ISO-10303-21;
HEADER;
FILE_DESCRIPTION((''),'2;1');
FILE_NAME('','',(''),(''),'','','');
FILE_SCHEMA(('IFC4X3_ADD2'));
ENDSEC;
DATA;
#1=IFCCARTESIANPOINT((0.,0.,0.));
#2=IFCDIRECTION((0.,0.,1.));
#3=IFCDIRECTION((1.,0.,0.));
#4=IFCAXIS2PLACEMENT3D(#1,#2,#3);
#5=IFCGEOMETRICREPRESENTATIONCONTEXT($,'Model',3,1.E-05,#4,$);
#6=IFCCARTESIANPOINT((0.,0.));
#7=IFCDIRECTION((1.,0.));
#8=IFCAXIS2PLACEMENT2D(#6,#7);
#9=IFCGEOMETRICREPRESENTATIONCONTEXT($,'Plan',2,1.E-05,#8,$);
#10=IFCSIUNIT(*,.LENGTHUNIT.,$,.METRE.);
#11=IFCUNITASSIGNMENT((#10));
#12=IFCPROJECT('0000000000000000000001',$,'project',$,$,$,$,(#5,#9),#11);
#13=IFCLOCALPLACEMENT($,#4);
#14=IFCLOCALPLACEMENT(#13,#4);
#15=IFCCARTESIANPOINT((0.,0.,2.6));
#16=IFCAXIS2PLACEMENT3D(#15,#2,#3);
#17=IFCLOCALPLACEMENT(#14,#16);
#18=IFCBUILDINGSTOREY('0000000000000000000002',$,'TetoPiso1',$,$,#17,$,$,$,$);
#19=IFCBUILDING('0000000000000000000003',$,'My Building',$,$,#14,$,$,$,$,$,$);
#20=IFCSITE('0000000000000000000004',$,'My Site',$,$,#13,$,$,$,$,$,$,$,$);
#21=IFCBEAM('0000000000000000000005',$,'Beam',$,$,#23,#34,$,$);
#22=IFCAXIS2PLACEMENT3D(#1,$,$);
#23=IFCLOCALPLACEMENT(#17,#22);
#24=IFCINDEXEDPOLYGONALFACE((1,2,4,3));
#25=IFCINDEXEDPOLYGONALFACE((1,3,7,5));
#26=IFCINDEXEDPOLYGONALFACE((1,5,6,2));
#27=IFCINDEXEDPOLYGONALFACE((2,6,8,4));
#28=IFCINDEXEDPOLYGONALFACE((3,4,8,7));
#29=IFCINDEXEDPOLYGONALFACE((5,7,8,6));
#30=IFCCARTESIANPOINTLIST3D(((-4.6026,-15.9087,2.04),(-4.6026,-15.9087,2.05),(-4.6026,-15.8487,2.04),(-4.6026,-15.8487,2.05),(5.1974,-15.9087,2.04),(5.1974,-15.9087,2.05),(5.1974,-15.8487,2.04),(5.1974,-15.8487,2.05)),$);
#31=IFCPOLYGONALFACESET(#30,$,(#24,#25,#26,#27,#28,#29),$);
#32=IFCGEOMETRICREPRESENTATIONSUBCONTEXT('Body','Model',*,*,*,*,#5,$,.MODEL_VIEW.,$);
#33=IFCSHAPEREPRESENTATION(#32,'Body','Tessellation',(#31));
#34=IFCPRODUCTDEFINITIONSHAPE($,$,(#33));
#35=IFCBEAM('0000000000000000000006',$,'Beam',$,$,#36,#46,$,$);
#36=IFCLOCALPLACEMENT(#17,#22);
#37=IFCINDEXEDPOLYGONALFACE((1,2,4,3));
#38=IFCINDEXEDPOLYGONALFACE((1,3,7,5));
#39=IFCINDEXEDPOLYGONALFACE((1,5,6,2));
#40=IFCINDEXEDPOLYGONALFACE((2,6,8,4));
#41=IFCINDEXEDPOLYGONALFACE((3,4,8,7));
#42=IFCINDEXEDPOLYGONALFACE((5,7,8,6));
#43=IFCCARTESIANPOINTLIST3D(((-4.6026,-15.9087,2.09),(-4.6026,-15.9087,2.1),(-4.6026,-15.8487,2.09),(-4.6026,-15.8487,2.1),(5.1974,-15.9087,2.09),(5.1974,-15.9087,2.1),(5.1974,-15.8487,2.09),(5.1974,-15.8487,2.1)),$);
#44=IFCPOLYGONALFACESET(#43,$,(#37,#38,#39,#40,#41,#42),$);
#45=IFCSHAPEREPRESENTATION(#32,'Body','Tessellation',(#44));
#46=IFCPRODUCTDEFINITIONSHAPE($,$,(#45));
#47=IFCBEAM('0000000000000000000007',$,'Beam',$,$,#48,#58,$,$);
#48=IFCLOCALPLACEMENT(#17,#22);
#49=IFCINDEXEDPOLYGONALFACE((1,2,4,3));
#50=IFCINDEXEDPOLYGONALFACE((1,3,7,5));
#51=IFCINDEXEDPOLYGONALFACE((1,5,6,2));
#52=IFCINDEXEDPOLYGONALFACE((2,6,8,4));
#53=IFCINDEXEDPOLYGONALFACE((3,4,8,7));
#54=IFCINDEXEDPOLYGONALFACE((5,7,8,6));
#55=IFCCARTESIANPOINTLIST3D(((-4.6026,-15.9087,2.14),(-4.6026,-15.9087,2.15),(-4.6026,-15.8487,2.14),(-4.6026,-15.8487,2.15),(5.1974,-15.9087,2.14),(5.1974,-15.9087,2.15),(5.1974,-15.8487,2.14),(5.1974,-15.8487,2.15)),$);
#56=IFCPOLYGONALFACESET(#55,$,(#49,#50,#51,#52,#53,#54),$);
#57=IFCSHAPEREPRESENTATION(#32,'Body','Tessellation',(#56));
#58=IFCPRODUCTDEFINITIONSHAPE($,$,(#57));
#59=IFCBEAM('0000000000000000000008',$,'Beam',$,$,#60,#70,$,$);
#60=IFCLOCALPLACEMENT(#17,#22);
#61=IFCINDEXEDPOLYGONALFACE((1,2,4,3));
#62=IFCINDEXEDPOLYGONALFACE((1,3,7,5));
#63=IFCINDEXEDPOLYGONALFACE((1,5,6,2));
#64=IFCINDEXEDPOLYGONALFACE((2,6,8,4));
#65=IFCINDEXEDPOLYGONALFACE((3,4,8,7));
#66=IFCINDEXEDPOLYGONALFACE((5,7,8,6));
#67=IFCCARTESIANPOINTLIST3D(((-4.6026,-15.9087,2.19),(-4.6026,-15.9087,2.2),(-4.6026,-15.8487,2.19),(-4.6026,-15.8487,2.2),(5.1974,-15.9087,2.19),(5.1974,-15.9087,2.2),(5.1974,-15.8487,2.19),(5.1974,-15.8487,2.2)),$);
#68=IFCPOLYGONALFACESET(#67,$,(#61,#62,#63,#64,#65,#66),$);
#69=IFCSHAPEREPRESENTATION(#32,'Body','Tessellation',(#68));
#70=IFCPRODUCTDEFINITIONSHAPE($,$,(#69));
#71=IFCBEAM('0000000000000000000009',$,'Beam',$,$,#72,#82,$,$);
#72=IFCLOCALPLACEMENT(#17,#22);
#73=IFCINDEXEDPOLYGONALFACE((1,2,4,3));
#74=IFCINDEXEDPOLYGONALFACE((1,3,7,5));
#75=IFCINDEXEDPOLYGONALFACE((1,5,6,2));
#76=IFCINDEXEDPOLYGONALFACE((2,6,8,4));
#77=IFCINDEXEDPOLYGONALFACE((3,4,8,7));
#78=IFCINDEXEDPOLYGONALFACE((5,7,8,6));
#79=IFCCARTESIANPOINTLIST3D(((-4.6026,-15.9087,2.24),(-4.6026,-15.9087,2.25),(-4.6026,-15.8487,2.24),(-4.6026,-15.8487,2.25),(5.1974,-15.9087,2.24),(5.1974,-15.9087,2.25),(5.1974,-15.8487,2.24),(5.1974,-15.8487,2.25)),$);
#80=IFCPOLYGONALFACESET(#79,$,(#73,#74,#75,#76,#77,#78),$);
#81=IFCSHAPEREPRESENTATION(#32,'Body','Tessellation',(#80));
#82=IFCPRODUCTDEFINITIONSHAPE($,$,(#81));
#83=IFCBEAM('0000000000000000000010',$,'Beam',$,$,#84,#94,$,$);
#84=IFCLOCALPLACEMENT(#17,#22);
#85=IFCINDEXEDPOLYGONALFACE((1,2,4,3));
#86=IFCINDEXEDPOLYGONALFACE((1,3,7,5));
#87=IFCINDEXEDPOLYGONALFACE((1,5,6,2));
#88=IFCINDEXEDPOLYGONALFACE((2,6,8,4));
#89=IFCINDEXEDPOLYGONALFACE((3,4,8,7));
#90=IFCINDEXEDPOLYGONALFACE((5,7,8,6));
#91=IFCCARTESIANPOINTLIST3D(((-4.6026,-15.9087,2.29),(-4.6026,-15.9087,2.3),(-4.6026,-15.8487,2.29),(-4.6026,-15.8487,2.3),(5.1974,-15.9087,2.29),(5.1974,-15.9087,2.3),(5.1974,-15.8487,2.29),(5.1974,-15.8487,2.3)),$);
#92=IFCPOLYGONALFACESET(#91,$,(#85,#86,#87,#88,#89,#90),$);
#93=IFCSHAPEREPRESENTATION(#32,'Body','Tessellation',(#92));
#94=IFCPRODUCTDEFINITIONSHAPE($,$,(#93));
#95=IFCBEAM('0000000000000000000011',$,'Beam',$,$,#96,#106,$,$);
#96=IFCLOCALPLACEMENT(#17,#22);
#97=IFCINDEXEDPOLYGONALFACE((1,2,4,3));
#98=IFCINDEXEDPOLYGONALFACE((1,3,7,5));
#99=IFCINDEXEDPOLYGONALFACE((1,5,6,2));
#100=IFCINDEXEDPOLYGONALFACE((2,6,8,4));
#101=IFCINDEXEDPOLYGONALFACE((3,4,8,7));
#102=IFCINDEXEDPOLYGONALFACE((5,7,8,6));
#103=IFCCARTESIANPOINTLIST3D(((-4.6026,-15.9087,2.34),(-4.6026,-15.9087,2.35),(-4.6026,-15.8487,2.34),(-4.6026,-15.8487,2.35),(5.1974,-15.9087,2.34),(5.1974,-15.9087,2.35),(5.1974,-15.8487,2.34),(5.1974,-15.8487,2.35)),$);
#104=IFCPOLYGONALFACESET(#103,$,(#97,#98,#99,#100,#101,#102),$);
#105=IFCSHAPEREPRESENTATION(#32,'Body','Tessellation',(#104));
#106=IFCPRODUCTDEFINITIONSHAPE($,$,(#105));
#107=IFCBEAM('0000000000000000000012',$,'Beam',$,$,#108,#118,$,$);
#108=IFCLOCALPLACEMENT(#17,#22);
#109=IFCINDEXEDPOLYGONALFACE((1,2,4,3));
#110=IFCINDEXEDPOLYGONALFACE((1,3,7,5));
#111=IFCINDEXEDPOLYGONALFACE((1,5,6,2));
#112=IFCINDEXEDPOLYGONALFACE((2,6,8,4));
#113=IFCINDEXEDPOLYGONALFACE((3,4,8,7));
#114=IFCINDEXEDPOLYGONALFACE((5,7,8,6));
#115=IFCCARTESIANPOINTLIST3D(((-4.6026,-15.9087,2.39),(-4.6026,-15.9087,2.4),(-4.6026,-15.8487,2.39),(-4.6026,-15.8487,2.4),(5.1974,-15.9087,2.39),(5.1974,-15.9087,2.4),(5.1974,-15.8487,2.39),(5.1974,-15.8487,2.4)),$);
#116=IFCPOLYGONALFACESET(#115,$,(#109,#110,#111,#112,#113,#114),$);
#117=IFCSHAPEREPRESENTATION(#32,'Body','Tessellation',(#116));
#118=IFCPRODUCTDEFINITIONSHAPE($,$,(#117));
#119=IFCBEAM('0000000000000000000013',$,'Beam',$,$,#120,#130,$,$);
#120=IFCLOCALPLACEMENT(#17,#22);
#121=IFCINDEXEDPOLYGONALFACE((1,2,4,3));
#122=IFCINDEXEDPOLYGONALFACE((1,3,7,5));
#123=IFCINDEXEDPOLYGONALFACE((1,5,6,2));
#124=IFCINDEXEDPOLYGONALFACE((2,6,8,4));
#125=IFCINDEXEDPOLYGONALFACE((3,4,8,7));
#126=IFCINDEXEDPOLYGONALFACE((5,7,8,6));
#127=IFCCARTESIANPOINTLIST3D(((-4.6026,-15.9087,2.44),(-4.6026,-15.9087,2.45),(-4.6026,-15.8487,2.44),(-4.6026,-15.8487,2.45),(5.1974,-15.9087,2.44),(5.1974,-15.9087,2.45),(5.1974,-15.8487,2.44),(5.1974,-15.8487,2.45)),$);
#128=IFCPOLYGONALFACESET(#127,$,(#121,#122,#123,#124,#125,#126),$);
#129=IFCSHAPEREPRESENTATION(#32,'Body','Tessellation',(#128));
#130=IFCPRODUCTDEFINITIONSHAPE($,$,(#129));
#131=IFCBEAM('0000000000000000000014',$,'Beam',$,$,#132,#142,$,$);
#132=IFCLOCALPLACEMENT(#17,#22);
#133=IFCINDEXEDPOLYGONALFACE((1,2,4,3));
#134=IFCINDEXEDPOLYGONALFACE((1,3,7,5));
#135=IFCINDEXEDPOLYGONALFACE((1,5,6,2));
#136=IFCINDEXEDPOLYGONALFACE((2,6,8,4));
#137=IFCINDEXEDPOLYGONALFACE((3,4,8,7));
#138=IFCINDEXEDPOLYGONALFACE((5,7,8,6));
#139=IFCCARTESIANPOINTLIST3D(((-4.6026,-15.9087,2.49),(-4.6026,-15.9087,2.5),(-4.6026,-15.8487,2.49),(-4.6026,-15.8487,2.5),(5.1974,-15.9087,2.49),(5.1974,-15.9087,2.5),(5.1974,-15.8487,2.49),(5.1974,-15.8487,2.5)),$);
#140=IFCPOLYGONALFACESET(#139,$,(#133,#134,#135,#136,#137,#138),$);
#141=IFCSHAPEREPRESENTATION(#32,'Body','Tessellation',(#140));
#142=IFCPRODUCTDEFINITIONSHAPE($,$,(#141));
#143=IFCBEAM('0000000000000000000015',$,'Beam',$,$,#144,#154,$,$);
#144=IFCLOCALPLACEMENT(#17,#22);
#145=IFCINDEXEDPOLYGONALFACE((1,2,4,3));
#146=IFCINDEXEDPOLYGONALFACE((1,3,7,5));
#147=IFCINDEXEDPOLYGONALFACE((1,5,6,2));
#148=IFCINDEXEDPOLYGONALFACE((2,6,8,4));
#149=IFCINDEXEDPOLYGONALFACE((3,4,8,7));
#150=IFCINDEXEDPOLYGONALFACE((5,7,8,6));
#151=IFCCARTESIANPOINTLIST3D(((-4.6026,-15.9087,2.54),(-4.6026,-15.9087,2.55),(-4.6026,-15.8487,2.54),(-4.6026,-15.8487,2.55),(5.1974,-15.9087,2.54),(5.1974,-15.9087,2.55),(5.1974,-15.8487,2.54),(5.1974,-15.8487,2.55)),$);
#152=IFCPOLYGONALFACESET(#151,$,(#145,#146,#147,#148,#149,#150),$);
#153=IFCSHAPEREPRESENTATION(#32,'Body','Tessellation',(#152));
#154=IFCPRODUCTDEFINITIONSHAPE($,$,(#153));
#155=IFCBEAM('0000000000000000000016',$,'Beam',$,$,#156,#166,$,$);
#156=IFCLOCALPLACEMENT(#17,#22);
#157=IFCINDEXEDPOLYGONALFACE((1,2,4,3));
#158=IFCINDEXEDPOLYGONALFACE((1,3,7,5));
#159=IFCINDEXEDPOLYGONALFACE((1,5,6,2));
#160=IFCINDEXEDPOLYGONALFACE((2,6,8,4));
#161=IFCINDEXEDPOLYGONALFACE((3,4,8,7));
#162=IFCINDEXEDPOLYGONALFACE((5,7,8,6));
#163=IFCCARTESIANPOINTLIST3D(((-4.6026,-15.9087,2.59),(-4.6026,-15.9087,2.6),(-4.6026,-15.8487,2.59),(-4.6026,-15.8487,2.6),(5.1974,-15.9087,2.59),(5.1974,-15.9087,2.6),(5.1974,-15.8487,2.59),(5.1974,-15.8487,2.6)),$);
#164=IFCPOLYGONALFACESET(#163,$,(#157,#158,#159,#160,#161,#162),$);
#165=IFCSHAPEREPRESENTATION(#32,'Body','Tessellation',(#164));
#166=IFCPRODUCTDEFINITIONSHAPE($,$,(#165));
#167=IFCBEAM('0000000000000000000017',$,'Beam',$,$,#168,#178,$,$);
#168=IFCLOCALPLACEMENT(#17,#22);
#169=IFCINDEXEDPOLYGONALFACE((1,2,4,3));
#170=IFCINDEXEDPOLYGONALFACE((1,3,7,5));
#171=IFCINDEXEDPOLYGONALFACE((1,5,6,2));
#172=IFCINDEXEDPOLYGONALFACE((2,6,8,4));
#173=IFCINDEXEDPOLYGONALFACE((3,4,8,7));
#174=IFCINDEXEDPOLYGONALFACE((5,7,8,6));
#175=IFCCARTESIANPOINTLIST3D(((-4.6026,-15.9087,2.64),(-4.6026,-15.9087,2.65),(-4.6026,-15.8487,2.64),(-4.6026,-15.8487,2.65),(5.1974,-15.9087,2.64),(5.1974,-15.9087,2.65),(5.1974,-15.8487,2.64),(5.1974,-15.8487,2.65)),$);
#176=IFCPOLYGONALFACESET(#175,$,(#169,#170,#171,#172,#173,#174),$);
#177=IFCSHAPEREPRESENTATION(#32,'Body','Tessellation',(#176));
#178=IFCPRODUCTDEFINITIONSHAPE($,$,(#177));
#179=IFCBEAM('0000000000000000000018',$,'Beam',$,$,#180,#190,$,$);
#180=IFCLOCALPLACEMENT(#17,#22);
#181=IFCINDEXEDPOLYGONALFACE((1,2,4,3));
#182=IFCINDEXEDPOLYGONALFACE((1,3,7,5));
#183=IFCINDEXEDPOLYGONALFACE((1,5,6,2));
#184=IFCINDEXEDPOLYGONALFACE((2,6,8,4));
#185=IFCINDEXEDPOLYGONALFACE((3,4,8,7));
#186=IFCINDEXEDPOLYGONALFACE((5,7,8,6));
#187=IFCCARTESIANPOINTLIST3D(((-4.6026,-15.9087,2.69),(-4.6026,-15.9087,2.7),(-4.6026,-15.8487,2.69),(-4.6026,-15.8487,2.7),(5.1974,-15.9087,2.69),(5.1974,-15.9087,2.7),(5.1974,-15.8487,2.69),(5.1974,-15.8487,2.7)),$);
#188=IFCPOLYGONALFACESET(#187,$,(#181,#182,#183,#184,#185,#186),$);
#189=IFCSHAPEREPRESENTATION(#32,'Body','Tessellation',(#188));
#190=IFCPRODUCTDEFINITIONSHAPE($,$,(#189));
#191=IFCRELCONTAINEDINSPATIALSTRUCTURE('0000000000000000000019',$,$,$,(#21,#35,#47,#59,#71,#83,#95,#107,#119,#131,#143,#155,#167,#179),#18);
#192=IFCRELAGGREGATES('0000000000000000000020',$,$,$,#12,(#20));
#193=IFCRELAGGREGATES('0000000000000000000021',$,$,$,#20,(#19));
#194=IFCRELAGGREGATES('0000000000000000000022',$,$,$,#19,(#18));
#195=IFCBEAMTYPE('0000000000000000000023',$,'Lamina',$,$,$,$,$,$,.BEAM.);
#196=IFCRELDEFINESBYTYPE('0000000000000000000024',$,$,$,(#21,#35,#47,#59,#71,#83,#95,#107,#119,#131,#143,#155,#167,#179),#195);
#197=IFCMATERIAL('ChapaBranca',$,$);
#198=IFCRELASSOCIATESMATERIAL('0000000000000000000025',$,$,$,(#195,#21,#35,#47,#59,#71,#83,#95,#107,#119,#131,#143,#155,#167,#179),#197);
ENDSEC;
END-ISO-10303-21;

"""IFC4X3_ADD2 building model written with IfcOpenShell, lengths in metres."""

from ifc_helpers import new_model, si_unit, frame, origin_with_axes, origin_2d, origin_2d_with_axis, place, context, subcontext, project, spatial, rectangle, extrude, material, material_profile, profile_set, profile_usage, type_object, element, save


model = new_model("IFC4X3_ADD2")

# Units and contexts
model_context = context("Model", 3, precision=1e-05, world=origin_with_axes())
plan_context = context("Plan", 2, precision=1e-05, world=origin_2d_with_axis())
body_context = subcontext(model_context, "Body", "Model", "MODEL_VIEW")
ifc_project = project(units=[si_unit("LENGTHUNIT", "METRE")], contexts=[model_context, plan_context])

# Site, building, storey
site_placement = place(None, origin_with_axes())
site = spatial("IfcSite", under=ifc_project, at=site_placement, Name="My Site")
building_placement = place(site_placement, origin_with_axes())
building = spatial("IfcBuilding", under=site, at=building_placement, Name="My Building")
storey_placement = place(building_placement, frame((0.0, 0.0, 2.6), z_axis=(0.0, 0.0, 1.0), x_axis=(1.0, 0.0, 0.0)))
storey = spatial("IfcBuildingStorey", under=building, at=storey_placement, Name="TetoPiso1")

# Beams
ifc_material = material(Name="ChapaBranca")
ifc_material_profile = material_profile(ifc_material, rectangle(XDim=0.06, YDim=0.01, at=origin_2d()))
ifc_profile_set = profile_set([ifc_material_profile])
beam_type = type_object("IfcBeamType", Name="Lamina", PredefinedType="BEAM", material=ifc_profile_set)
ifc_profile_usage_1 = profile_usage(ifc_profile_set, cardinal=5)
beam_1_placement = place(storey_placement, frame((-4.6026, -15.8787, 2.045), z_axis=(1.0, 0.0, 0.0), x_axis=(0.0, 1.0, 0.0)))
element("IfcBeam", 1, at=beam_1_placement, inside=storey, type_object=beam_type, material=ifc_profile_usage_1, Name="Beam", context=body_context, shape_type="SweptSolid", body=[
    extrude(rectangle(XDim=0.06, YDim=0.01, at=origin_2d()), origin_with_axes(), (0.0, 0.0, 1.0), 9.8),
])
ifc_profile_usage_2 = profile_usage(ifc_profile_set, cardinal=5)
beam_2_placement = place(storey_placement, frame((-4.6026, -15.8787, 2.095), z_axis=(1.0, 0.0, 0.0), x_axis=(0.0, 1.0, 0.0)))
element("IfcBeam", 2, at=beam_2_placement, inside=storey, type_object=beam_type, material=ifc_profile_usage_2, Name="Beam", context=body_context, shape_type="SweptSolid", body=[
    extrude(rectangle(XDim=0.06, YDim=0.01, at=origin_2d()), origin_with_axes(), (0.0, 0.0, 1.0), 9.8),
])
ifc_profile_usage_3 = profile_usage(ifc_profile_set, cardinal=5)
beam_3_placement = place(storey_placement, frame((-4.6026, -15.8787, 2.145), z_axis=(1.0, 0.0, 0.0), x_axis=(0.0, 1.0, 0.0)))
element("IfcBeam", 3, at=beam_3_placement, inside=storey, type_object=beam_type, material=ifc_profile_usage_3, Name="Beam", context=body_context, shape_type="SweptSolid", body=[
    extrude(rectangle(XDim=0.06, YDim=0.01, at=origin_2d()), origin_with_axes(), (0.0, 0.0, 1.0), 9.8),
])
ifc_profile_usage_4 = profile_usage(ifc_profile_set, cardinal=5)
beam_4_placement = place(storey_placement, frame((-4.6026, -15.8787, 2.195), z_axis=(1.0, 0.0, 0.0), x_axis=(0.0, 1.0, 0.0)))
element("IfcBeam", 4, at=beam_4_placement, inside=storey, type_object=beam_type, material=ifc_profile_usage_4, Name="Beam", context=body_context, shape_type="SweptSolid", body=[
    extrude(rectangle(XDim=0.06, YDim=0.01, at=origin_2d()), origin_with_axes(), (0.0, 0.0, 1.0), 9.8),
])
ifc_profile_usage_5 = profile_usage(ifc_profile_set, cardinal=5)
beam_5_placement = place(storey_placement, frame((-4.6026, -15.8787, 2.245), z_axis=(1.0, 0.0, 0.0), x_axis=(0.0, 1.0, 0.0)))
element("IfcBeam", 5, at=beam_5_placement, inside=storey, type_object=beam_type, material=ifc_profile_usage_5, Name="Beam", context=body_context, shape_type="SweptSolid", body=[
    extrude(rectangle(XDim=0.06, YDim=0.01, at=origin_2d()), origin_with_axes(), (0.0, 0.0, 1.0), 9.8),
])
ifc_profile_usage_6 = profile_usage(ifc_profile_set, cardinal=5)
beam_6_placement = place(storey_placement, frame((-4.6026, -15.8787, 2.295), z_axis=(1.0, 0.0, 0.0), x_axis=(0.0, 1.0, 0.0)))
element("IfcBeam", 6, at=beam_6_placement, inside=storey, type_object=beam_type, material=ifc_profile_usage_6, Name="Beam", context=body_context, shape_type="SweptSolid", body=[
    extrude(rectangle(XDim=0.06, YDim=0.01, at=origin_2d()), origin_with_axes(), (0.0, 0.0, 1.0), 9.8),
])
ifc_profile_usage_7 = profile_usage(ifc_profile_set, cardinal=5)
beam_7_placement = place(storey_placement, frame((-4.6026, -15.8787, 2.345), z_axis=(1.0, 0.0, 0.0), x_axis=(0.0, 1.0, 0.0)))
element("IfcBeam", 7, at=beam_7_placement, inside=storey, type_object=beam_type, material=ifc_profile_usage_7, Name="Beam", context=body_context, shape_type="SweptSolid", body=[
    extrude(rectangle(XDim=0.06, YDim=0.01, at=origin_2d()), origin_with_axes(), (0.0, 0.0, 1.0), 9.8),
])
ifc_profile_usage_8 = profile_usage(ifc_profile_set, cardinal=5)
beam_8_placement = place(storey_placement, frame((-4.6026, -15.8787, 2.395), z_axis=(1.0, 0.0, 0.0), x_axis=(0.0, 1.0, 0.0)))
element("IfcBeam", 8, at=beam_8_placement, inside=storey, type_object=beam_type, material=ifc_profile_usage_8, Name="Beam", context=body_context, shape_type="SweptSolid", body=[
    extrude(rectangle(XDim=0.06, YDim=0.01, at=origin_2d()), origin_with_axes(), (0.0, 0.0, 1.0), 9.8),
])
ifc_profile_usage_9 = profile_usage(ifc_profile_set, cardinal=5)
beam_9_placement = place(storey_placement, frame((-4.6026, -15.8787, 2.445), z_axis=(1.0, 0.0, 0.0), x_axis=(0.0, 1.0, 0.0)))
element("IfcBeam", 9, at=beam_9_placement, inside=storey, type_object=beam_type, material=ifc_profile_usage_9, Name="Beam", context=body_context, shape_type="SweptSolid", body=[
    extrude(rectangle(XDim=0.06, YDim=0.01, at=origin_2d()), origin_with_axes(), (0.0, 0.0, 1.0), 9.8),
])
ifc_profile_usage_10 = profile_usage(ifc_profile_set, cardinal=5)
beam_10_placement = place(storey_placement, frame((-4.6026, -15.8787, 2.495), z_axis=(1.0, 0.0, 0.0), x_axis=(0.0, 1.0, 0.0)))
element("IfcBeam", 10, at=beam_10_placement, inside=storey, type_object=beam_type, material=ifc_profile_usage_10, Name="Beam", context=body_context, shape_type="SweptSolid", body=[
    extrude(rectangle(XDim=0.06, YDim=0.01, at=origin_2d()), origin_with_axes(), (0.0, 0.0, 1.0), 9.8),
])
ifc_profile_usage_11 = profile_usage(ifc_profile_set, cardinal=5)
beam_11_placement = place(storey_placement, frame((-4.6026, -15.8787, 2.545), z_axis=(1.0, 0.0, 0.0), x_axis=(0.0, 1.0, 0.0)))
element("IfcBeam", 11, at=beam_11_placement, inside=storey, type_object=beam_type, material=ifc_profile_usage_11, Name="Beam", context=body_context, shape_type="SweptSolid", body=[
    extrude(rectangle(XDim=0.06, YDim=0.01, at=origin_2d()), origin_with_axes(), (0.0, 0.0, 1.0), 9.8),
])
ifc_profile_usage_12 = profile_usage(ifc_profile_set, cardinal=5)
beam_12_placement = place(storey_placement, frame((-4.6026, -15.8787, 2.595), z_axis=(1.0, 0.0, 0.0), x_axis=(0.0, 1.0, 0.0)))
element("IfcBeam", 12, at=beam_12_placement, inside=storey, type_object=beam_type, material=ifc_profile_usage_12, Name="Beam", context=body_context, shape_type="SweptSolid", body=[
    extrude(rectangle(XDim=0.06, YDim=0.01, at=origin_2d()), origin_with_axes(), (0.0, 0.0, 1.0), 9.8),
])
ifc_profile_usage_13 = profile_usage(ifc_profile_set, cardinal=5)
beam_13_placement = place(storey_placement, frame((-4.6026, -15.8787, 2.645), z_axis=(1.0, 0.0, 0.0), x_axis=(0.0, 1.0, 0.0)))
element("IfcBeam", 13, at=beam_13_placement, inside=storey, type_object=beam_type, material=ifc_profile_usage_13, Name="Beam", context=body_context, shape_type="SweptSolid", body=[
    extrude(rectangle(XDim=0.06, YDim=0.01, at=origin_2d()), origin_with_axes(), (0.0, 0.0, 1.0), 9.8),
])
ifc_profile_usage_14 = profile_usage(ifc_profile_set, cardinal=5)
beam_14_placement = place(storey_placement, frame((-4.6026, -15.8787, 2.695), z_axis=(1.0, 0.0, 0.0), x_axis=(0.0, 1.0, 0.0)))
element("IfcBeam", 14, at=beam_14_placement, inside=storey, type_object=beam_type, material=ifc_profile_usage_14, Name="Beam", context=body_context, shape_type="SweptSolid", body=[
    extrude(rectangle(XDim=0.06, YDim=0.01, at=origin_2d()), origin_with_axes(), (0.0, 0.0, 1.0), 9.8),
])

save(model, "model.ifc")
